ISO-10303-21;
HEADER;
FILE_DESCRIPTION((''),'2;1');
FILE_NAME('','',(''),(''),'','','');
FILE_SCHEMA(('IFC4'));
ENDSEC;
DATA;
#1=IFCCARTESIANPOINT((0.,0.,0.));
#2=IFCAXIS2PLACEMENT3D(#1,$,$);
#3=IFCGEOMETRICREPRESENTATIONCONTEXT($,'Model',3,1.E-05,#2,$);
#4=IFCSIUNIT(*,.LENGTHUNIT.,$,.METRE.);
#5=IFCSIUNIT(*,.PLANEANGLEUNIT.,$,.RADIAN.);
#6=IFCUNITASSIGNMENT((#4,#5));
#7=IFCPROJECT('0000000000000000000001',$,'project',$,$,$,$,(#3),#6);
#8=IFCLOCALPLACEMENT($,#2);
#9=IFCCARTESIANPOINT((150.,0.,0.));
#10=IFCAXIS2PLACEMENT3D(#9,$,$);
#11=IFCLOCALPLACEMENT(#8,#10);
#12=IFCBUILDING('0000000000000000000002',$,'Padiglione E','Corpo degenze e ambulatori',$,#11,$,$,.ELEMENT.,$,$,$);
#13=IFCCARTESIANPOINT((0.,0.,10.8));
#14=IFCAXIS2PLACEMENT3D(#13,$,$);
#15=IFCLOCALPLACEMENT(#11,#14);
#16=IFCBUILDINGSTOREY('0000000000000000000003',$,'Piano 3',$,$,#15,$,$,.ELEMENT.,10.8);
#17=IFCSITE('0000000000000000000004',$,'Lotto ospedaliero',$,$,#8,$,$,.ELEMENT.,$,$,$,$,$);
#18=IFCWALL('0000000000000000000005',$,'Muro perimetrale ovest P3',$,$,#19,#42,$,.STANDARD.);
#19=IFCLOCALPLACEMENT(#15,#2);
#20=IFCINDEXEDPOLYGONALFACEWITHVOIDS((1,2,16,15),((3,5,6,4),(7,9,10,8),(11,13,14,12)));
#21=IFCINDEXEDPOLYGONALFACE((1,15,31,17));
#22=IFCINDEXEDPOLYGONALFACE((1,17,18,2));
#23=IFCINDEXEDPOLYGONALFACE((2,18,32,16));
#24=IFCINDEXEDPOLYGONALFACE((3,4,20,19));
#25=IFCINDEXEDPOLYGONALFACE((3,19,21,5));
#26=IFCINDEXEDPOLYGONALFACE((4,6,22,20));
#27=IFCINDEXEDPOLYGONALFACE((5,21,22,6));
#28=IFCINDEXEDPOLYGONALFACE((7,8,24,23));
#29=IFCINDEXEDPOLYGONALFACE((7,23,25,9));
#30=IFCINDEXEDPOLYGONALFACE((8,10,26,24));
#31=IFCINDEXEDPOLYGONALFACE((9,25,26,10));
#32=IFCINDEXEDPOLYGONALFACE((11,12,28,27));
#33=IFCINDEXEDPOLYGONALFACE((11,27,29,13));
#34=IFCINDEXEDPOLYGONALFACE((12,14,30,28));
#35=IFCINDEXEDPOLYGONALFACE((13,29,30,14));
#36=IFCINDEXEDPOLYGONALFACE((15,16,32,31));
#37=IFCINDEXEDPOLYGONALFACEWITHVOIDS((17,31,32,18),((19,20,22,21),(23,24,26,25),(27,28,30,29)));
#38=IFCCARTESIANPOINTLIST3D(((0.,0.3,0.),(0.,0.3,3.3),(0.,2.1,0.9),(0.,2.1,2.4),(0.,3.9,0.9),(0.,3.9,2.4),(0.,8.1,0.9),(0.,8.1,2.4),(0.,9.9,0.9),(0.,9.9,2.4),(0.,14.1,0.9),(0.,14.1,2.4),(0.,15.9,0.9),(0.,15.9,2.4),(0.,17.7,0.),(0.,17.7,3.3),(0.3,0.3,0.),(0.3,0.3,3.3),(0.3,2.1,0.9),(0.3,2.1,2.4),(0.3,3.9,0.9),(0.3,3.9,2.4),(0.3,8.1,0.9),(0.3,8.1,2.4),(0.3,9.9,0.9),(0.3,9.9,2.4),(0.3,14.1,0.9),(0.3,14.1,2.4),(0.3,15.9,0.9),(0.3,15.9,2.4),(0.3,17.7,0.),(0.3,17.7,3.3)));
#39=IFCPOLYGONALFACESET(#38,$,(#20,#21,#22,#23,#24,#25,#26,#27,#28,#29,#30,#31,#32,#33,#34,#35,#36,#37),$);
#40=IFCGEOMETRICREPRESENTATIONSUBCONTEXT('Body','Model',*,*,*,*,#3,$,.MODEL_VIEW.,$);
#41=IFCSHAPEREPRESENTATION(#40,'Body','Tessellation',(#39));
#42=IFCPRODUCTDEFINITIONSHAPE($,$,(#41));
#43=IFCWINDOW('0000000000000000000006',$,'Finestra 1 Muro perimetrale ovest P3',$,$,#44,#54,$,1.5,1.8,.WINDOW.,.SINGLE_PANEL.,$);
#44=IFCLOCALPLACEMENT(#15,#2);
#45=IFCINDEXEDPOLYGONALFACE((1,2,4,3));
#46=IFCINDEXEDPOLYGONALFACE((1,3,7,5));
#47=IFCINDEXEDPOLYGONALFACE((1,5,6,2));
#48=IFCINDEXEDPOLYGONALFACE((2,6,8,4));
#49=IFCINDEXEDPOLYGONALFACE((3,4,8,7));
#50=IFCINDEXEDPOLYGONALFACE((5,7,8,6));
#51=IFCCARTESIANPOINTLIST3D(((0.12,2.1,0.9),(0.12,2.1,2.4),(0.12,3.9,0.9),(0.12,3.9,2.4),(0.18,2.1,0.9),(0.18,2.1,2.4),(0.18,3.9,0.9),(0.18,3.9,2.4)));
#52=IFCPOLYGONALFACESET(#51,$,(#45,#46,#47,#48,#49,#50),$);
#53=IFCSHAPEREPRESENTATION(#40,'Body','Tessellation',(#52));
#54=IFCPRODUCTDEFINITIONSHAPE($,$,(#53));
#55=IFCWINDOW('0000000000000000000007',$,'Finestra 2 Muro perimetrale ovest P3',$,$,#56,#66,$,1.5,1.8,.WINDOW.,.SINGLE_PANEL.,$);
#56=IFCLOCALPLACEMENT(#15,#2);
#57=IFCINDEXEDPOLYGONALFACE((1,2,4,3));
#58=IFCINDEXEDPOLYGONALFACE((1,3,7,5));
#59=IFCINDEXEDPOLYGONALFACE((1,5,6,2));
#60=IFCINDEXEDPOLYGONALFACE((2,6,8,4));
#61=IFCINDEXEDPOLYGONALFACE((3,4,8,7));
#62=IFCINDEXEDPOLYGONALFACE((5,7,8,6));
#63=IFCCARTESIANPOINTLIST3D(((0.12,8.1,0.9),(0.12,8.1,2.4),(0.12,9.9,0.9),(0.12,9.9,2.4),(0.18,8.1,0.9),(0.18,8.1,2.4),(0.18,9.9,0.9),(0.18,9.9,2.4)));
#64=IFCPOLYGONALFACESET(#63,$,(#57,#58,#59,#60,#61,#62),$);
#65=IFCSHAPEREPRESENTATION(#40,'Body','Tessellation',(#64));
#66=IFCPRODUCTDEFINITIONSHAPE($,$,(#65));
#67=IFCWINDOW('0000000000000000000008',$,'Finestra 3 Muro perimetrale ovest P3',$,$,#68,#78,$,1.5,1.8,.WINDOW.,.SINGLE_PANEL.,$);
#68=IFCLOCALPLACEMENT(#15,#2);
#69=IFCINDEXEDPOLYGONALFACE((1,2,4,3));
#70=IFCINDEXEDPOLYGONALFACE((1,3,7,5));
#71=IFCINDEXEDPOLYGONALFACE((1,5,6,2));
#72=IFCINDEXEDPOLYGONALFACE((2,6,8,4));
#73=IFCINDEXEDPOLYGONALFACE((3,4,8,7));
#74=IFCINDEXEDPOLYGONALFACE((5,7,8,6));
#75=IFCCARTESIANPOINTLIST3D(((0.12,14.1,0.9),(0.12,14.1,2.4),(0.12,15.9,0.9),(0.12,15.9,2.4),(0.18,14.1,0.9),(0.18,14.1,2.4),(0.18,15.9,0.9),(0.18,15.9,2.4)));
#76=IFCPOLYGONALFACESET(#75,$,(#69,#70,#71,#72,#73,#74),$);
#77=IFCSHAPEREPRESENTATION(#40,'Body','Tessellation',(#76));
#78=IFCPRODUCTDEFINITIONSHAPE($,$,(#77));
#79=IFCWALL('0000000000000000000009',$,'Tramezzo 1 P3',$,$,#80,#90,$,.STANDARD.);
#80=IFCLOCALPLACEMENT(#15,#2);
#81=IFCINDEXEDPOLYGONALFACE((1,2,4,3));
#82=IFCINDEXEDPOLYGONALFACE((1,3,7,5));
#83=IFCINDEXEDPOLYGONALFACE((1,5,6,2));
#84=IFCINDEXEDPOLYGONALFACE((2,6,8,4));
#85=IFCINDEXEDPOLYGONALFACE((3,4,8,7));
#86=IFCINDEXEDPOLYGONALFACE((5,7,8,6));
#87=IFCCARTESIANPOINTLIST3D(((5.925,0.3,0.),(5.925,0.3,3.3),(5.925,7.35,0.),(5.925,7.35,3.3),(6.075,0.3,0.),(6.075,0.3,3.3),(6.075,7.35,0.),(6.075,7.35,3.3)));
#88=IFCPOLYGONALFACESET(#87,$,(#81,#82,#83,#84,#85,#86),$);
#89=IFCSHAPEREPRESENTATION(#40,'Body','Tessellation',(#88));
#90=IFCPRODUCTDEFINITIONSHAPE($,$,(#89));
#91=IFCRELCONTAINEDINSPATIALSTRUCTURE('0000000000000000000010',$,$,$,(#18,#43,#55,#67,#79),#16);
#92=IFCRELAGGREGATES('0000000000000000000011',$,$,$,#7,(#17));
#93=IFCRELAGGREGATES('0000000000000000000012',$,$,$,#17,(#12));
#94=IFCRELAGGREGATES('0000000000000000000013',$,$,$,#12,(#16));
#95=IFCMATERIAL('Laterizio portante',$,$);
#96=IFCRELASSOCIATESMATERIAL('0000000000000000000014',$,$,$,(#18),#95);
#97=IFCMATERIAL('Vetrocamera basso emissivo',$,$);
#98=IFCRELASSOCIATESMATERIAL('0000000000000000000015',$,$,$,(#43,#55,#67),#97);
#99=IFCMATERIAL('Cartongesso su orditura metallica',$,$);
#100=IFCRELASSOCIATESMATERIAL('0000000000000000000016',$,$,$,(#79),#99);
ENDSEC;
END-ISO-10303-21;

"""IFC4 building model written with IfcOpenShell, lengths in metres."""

from ifc_helpers import new_model, si_unit, frame, frame_2d, origin, place, context, subcontext, project, spatial, rectangle, extrude, material, element, fill, save


model = new_model("IFC4")

# Units and contexts
model_context = context("Model", 3, precision=1e-05, world=origin())
body_context = subcontext(model_context, "Body", "Model", "MODEL_VIEW")
ifc_project = project(units=[si_unit("LENGTHUNIT", "METRE"), si_unit("PLANEANGLEUNIT", "RADIAN")], contexts=[model_context])

# Site, building, storey
site_placement = place(None, origin())
site = spatial("IfcSite", under=ifc_project, at=site_placement, Name="Lotto ospedaliero", CompositionType="ELEMENT")
building_placement = place(site_placement, frame((150.0, 0.0, 0.0)))
building = spatial("IfcBuilding", under=site, at=building_placement, Name="Padiglione E", Description="Corpo degenze e ambulatori", CompositionType="ELEMENT")
storey_placement = place(building_placement, frame((0.0, 0.0, 10.8)))
storey = spatial("IfcBuildingStorey", under=building, at=storey_placement, Name="Piano 3", CompositionType="ELEMENT", Elevation=10.8)

# Wall, openings, windows
ifc_material_1 = material(Name="Laterizio portante")
ifc_material_2 = material(Name="Vetrocamera basso emissivo")
wall_1_placement = place(storey_placement, frame((0.0, 0.3, 0.0)))
wall_1 = element("IfcWall", 1, at=wall_1_placement, inside=storey, material=ifc_material_1, Name="Muro perimetrale ovest P3", PredefinedType="STANDARD", context=body_context, shape_type="SweptSolid", body=[
    extrude(rectangle(XDim=0.3, YDim=17.4, at=frame_2d((0.15, 8.7))), origin(), (0.0, 0.0, 1.0), 3.3),
])
opening_1_placement = place(wall_1_placement, frame((-0.1, 1.8, 0.9)))
opening_1 = element("IfcOpeningElement", 2, at=opening_1_placement, cuts=wall_1, PredefinedType="OPENING", context=body_context, shape_type="SweptSolid", body=[
    extrude(rectangle(XDim=0.5, YDim=1.8, at=frame_2d((0.25, 0.9))), origin(), (0.0, 0.0, 1.0), 1.5),
])
opening_2_placement = place(wall_1_placement, frame((-0.1, 7.8, 0.9)))
opening_2 = element("IfcOpeningElement", 3, at=opening_2_placement, cuts=wall_1, PredefinedType="OPENING", context=body_context, shape_type="SweptSolid", body=[
    extrude(rectangle(XDim=0.5, YDim=1.8, at=frame_2d((0.25, 0.9))), origin(), (0.0, 0.0, 1.0), 1.5),
])
opening_3_placement = place(wall_1_placement, frame((-0.1, 13.8, 0.9)))
opening_3 = element("IfcOpeningElement", 4, at=opening_3_placement, cuts=wall_1, PredefinedType="OPENING", context=body_context, shape_type="SweptSolid", body=[
    extrude(rectangle(XDim=0.5, YDim=1.8, at=frame_2d((0.25, 0.9))), origin(), (0.0, 0.0, 1.0), 1.5),
])
window_1_placement = place(wall_1_placement, frame((0.12, 1.8, 0.9)))
window_1 = element("IfcWindow", 5, at=window_1_placement, inside=storey, material=ifc_material_2, Name="Finestra 1 Muro perimetrale ovest P3", OverallHeight=1.5, OverallWidth=1.8, PartitioningType="SINGLE_PANEL", PredefinedType="WINDOW", context=body_context, shape_type="SweptSolid", body=[
    extrude(rectangle(XDim=0.06, YDim=1.8, at=frame_2d((0.03, 0.9))), origin(), (0.0, 0.0, 1.0), 1.5),
])
fill(opening_1, window_1)
window_2_placement = place(wall_1_placement, frame((0.12, 7.8, 0.9)))
window_2 = element("IfcWindow", 6, at=window_2_placement, inside=storey, material=ifc_material_2, Name="Finestra 2 Muro perimetrale ovest P3", OverallHeight=1.5, OverallWidth=1.8, PartitioningType="SINGLE_PANEL", PredefinedType="WINDOW", context=body_context, shape_type="SweptSolid", body=[
    extrude(rectangle(XDim=0.06, YDim=1.8, at=frame_2d((0.03, 0.9))), origin(), (0.0, 0.0, 1.0), 1.5),
])
fill(opening_2, window_2)
window_3_placement = place(wall_1_placement, frame((0.12, 13.8, 0.9)))
window_3 = element("IfcWindow", 7, at=window_3_placement, inside=storey, material=ifc_material_2, Name="Finestra 3 Muro perimetrale ovest P3", OverallHeight=1.5, OverallWidth=1.8, PartitioningType="SINGLE_PANEL", PredefinedType="WINDOW", context=body_context, shape_type="SweptSolid", body=[
    extrude(rectangle(XDim=0.06, YDim=1.8, at=frame_2d((0.03, 0.9))), origin(), (0.0, 0.0, 1.0), 1.5),
])
fill(opening_3, window_3)

# Wall
ifc_material_3 = material(Name="Cartongesso su orditura metallica")
wall_2_placement = place(storey_placement, frame((5.925, 0.3, 0.0)))
element("IfcWall", 8, at=wall_2_placement, inside=storey, material=ifc_material_3, Name="Tramezzo 1 P3", PredefinedType="STANDARD", context=body_context, shape_type="SweptSolid", body=[
    extrude(rectangle(XDim=0.15, YDim=7.05, at=frame_2d((0.075, 3.525))), origin(), (0.0, 0.0, 1.0), 3.3),
])

save(model, "model.ifc")
